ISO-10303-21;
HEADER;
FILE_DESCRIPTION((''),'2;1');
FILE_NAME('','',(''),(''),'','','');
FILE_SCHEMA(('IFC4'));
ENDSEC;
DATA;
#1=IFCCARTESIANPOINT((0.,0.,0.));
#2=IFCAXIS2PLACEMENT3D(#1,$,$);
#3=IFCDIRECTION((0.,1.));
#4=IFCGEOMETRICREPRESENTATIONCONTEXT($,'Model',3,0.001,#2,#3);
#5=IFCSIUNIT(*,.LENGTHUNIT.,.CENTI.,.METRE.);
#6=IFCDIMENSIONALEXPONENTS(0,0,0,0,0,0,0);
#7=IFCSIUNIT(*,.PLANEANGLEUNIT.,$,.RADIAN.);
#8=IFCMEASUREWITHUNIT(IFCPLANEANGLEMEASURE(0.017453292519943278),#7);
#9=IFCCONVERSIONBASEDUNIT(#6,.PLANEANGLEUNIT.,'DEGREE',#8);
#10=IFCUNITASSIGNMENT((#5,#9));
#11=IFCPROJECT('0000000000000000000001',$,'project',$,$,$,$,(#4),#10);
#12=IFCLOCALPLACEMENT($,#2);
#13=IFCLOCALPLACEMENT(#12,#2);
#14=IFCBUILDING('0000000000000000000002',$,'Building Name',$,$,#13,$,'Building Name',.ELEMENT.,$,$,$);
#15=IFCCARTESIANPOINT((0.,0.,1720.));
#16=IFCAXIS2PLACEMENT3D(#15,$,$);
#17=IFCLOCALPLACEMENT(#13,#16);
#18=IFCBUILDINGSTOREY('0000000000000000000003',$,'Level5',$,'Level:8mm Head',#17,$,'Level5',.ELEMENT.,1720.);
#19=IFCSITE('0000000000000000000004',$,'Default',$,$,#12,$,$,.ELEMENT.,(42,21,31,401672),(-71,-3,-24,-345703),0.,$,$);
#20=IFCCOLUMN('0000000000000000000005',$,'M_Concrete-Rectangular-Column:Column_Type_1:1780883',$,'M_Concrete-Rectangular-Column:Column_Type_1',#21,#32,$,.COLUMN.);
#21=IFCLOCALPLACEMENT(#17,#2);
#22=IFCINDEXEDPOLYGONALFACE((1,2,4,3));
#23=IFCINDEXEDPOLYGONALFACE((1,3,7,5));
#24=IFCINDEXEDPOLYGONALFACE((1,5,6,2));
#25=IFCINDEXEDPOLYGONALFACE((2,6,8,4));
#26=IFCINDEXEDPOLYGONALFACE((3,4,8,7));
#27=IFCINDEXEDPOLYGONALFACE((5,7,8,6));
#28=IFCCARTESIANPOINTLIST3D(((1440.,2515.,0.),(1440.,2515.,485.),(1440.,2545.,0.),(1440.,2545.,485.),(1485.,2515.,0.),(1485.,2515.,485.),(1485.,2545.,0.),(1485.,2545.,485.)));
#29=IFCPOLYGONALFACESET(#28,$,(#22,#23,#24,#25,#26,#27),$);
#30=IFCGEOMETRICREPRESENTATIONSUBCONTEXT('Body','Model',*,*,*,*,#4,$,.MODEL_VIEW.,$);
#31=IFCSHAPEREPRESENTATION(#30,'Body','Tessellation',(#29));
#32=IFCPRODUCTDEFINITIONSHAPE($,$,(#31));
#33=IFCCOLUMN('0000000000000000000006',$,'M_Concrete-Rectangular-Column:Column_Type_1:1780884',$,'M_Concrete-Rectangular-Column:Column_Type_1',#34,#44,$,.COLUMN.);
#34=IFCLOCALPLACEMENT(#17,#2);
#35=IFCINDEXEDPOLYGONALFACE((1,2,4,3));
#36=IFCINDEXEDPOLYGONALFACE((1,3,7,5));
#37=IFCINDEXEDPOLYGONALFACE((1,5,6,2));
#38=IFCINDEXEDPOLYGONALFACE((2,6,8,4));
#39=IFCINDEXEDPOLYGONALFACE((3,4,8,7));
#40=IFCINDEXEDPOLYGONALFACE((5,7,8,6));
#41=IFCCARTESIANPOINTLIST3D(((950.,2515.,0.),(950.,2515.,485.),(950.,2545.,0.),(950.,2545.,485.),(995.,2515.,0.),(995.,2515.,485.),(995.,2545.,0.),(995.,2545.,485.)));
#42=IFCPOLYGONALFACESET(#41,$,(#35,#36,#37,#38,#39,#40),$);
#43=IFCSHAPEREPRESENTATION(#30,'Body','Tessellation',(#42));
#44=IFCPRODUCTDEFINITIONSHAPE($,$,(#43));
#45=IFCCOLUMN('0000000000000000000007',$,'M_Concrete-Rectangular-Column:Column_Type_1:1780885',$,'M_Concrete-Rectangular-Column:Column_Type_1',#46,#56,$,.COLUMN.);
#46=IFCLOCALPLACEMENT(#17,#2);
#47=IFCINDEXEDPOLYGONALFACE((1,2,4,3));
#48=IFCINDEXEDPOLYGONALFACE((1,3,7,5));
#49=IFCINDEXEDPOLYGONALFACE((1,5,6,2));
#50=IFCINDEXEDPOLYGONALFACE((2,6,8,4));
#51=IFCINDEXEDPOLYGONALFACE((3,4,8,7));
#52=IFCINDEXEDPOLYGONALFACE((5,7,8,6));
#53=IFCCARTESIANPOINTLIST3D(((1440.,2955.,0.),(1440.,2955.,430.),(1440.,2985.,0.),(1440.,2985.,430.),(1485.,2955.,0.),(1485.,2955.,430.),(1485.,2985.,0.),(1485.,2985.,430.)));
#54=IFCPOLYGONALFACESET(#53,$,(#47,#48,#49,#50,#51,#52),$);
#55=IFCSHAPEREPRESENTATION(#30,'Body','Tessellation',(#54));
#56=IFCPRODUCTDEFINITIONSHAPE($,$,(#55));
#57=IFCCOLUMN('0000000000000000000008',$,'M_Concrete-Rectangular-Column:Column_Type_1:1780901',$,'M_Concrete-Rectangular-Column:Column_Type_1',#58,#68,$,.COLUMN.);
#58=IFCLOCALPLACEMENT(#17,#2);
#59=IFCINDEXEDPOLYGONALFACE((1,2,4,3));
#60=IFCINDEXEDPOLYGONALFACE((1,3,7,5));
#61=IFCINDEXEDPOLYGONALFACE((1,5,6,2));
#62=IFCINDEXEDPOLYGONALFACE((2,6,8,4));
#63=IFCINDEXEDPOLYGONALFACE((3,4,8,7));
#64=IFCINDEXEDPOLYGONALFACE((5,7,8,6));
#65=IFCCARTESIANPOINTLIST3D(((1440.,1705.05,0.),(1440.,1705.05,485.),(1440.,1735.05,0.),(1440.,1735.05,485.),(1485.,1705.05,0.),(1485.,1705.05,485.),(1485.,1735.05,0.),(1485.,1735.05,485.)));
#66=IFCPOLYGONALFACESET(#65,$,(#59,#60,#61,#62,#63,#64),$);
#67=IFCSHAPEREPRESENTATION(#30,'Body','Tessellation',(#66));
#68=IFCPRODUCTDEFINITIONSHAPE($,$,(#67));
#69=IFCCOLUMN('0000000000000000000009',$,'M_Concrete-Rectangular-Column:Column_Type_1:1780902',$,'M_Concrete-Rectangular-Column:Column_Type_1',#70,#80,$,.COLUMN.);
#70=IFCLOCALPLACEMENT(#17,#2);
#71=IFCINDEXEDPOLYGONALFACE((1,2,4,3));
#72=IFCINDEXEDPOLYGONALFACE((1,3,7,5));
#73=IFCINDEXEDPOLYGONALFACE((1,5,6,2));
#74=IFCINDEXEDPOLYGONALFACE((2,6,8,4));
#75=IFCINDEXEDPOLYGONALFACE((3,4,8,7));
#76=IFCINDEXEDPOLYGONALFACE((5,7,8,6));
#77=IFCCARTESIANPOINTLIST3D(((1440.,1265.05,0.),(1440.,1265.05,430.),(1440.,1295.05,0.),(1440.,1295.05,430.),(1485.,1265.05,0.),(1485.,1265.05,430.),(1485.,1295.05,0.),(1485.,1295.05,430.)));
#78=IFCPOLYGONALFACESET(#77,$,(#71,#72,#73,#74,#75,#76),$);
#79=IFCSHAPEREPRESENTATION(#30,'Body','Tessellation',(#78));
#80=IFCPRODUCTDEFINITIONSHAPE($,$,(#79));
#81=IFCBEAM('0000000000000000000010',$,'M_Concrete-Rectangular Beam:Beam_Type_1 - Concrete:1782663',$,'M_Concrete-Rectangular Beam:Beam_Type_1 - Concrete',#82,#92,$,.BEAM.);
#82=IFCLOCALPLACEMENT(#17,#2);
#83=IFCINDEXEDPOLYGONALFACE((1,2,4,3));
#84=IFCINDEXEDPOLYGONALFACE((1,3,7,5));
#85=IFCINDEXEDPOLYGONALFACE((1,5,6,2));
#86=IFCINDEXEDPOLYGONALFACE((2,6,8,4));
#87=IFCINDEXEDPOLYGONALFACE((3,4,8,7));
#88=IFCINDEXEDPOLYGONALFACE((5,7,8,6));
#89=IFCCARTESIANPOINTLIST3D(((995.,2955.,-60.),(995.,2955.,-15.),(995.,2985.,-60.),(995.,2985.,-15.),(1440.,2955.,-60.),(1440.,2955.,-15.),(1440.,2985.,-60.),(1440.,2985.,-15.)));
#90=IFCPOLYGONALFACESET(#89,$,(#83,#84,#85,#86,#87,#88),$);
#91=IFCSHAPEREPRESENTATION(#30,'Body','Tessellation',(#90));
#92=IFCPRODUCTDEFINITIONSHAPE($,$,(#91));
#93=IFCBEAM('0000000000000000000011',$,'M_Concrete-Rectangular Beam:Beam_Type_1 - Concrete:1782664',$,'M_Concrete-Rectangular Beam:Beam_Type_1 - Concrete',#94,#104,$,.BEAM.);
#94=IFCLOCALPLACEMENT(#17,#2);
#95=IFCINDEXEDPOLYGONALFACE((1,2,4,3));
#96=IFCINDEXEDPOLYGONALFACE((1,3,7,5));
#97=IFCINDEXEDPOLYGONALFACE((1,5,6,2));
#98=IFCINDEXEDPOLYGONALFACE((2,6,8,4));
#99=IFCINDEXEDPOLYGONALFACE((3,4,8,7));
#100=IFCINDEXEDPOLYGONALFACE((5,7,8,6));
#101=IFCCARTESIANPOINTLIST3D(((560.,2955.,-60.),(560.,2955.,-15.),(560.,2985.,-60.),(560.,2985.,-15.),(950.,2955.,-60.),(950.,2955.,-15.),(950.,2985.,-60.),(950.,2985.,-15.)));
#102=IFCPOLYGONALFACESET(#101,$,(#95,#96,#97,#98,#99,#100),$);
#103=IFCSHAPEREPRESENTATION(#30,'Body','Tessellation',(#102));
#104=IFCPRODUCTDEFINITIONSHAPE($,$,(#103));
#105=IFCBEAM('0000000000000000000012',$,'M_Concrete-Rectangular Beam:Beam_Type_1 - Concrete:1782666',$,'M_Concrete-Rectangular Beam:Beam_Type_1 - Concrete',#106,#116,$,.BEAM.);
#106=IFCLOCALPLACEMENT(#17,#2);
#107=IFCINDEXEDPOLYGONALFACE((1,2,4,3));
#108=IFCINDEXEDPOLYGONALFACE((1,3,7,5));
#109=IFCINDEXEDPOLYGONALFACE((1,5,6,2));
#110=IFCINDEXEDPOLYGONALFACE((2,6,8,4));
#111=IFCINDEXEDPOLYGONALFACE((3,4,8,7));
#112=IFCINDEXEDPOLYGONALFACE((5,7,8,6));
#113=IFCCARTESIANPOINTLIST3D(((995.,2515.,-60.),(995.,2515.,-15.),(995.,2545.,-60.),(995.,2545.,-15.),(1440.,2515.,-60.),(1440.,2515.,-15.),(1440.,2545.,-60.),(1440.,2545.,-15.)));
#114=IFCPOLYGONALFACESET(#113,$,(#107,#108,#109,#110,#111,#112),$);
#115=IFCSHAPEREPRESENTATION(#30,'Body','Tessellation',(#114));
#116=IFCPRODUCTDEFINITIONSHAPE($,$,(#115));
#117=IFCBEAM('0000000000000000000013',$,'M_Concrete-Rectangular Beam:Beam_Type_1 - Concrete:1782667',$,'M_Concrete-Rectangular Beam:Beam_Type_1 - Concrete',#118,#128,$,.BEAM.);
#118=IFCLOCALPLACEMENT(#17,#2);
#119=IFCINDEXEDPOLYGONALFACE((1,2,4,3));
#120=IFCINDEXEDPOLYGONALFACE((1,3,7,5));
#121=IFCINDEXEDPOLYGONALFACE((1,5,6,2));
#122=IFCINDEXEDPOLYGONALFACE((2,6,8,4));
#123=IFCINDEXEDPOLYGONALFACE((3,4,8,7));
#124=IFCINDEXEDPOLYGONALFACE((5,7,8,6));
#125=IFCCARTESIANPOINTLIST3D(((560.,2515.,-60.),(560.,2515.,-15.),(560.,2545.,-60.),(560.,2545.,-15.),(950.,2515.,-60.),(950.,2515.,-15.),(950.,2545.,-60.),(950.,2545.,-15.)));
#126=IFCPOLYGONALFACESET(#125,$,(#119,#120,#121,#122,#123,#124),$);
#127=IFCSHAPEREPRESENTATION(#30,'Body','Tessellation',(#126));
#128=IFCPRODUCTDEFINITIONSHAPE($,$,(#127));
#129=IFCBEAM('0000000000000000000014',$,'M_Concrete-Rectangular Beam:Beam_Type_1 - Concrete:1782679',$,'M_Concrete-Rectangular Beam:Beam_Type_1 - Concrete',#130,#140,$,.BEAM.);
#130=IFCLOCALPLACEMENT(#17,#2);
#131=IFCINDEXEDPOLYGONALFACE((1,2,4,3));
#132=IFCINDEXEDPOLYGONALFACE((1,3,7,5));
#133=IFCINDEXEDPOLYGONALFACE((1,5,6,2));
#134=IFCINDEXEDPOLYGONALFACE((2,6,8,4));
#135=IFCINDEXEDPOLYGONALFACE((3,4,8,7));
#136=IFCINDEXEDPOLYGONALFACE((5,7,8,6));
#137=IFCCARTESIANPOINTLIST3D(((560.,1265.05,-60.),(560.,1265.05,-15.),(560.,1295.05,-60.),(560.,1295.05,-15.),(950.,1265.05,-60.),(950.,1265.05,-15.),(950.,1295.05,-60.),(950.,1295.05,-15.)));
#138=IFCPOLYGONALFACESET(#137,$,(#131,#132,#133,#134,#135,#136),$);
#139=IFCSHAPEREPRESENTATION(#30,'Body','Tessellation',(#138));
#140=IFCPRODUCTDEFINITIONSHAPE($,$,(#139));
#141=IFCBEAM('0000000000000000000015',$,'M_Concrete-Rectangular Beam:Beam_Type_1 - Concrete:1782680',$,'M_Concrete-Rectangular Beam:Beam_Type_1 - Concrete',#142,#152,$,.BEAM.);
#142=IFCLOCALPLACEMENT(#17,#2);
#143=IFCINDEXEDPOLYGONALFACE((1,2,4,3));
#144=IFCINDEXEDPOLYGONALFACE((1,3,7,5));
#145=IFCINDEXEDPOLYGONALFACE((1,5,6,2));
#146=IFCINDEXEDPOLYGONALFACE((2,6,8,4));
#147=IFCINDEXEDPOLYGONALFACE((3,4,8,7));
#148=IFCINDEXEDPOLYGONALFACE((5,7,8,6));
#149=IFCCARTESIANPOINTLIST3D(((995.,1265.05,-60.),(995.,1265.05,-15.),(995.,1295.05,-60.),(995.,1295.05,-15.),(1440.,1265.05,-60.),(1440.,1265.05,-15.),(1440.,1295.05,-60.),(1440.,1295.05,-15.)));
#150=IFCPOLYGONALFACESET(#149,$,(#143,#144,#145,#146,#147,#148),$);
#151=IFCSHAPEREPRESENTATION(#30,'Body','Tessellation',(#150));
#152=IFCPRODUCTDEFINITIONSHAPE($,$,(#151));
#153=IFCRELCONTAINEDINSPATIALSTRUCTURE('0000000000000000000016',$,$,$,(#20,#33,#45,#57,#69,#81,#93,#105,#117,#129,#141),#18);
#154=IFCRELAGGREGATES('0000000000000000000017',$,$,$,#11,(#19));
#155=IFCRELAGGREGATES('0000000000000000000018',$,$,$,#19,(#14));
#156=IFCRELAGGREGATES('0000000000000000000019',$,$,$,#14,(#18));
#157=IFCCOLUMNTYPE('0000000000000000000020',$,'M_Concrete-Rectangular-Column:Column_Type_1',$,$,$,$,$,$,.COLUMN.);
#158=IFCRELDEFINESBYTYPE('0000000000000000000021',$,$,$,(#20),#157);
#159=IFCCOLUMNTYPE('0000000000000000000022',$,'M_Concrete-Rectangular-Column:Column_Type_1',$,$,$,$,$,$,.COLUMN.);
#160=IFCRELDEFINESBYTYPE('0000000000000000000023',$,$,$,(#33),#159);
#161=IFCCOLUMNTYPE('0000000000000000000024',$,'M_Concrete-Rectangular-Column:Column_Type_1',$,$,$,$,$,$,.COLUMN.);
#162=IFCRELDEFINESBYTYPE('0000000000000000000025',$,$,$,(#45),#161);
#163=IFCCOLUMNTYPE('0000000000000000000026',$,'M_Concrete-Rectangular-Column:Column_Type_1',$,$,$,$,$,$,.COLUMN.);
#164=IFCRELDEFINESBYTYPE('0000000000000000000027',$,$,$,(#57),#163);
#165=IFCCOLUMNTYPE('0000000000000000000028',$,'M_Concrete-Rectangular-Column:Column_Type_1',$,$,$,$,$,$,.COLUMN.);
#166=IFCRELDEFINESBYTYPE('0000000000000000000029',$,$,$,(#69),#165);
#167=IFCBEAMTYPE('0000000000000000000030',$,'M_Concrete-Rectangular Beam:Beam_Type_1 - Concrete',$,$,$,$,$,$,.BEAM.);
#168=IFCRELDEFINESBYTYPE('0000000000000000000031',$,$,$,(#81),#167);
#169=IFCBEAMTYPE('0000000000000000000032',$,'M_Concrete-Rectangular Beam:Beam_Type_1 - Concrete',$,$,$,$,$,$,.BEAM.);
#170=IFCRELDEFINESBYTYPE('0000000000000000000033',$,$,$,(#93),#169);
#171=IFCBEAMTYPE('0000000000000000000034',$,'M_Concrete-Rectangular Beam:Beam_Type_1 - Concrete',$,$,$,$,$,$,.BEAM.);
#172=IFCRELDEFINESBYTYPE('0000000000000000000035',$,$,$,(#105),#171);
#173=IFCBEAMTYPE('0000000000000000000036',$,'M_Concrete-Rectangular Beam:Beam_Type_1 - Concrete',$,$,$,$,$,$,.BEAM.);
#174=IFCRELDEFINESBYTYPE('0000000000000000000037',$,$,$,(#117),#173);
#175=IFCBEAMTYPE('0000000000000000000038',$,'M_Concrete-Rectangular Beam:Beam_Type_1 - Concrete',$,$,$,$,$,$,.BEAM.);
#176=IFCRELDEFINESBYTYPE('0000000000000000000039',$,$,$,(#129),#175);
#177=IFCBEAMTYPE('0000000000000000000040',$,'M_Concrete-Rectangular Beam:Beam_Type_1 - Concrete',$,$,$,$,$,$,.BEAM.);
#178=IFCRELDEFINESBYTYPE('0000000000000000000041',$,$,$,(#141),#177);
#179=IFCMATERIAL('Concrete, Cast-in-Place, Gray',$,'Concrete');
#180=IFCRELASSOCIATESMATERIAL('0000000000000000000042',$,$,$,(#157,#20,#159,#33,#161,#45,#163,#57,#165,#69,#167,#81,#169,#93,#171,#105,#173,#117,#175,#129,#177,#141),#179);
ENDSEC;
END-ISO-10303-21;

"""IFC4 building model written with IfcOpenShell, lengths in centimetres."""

from ifc_helpers import new_model, entity, si_unit, converted_unit, direction, frame, origin, place, context, subcontext, project, spatial, indexed_curve, outline, extrude, source, transform, mapped, material, type_object, type_shapes, element, save


model = new_model("IFC4")

# Units and contexts
model_context = context("Model", 3, precision=0.001, world=origin(), true_north=direction((0.0, 1.0)))
body_context = subcontext(model_context, "Body", "Model", "MODEL_VIEW")
ifc_project = project(units=[si_unit("LENGTHUNIT", "METRE", prefix="CENTI"), converted_unit("PLANEANGLEUNIT", "DEGREE", entity("IfcPlaneAngleMeasure", 0.017453292519943278), si_unit("PLANEANGLEUNIT", "RADIAN"), dimensions=[0, 0, 0, 0, 0, 0, 0])], contexts=[model_context])

# Site, building, storey
site_placement = place(None, origin())
site = spatial("IfcSite", under=ifc_project, at=site_placement, Name="Default", CompositionType="ELEMENT", RefLatitude=(42, 21, 31, 401672), RefLongitude=(-71, -3, -24, -345703), RefElevation=0.0)
building_placement = place(site_placement, origin())
building = spatial("IfcBuilding", under=site, at=building_placement, Name="Building Name", LongName="Building Name", CompositionType="ELEMENT")
storey_placement = place(building_placement, frame((0.0, 0.0, 1720.0)))
storey = spatial("IfcBuildingStorey", under=building, at=storey_placement, Name="Level5", ObjectType="Level:8mm Head", LongName="Level5", CompositionType="ELEMENT", Elevation=1720.0)

# Columns
ifc_material = material(Name="Concrete, Cast-in-Place, Gray", Category="Concrete")
column_type_1 = type_object("IfcColumnType", Name="M_Concrete-Rectangular-Column:Column_Type_1", PredefinedType="COLUMN", material=ifc_material)
shared_shape_1 = source(origin(), body_context, "Body", "SweptSolid", [
    extrude(outline(indexed_curve([(-15.0, -22.5), (15.0, -22.5), (15.0, 22.5), (-15.0, 22.5), (-15.0, -22.5)], self_intersect=False)), frame((1462.5, 2530.0, 1720.0), z_axis=(0.0, 0.0, 1.0), x_axis=(0.0, -1.0, 0.0)), (0.0, 0.0, 1.0), 485.0),
])
type_shapes(column_type_1, [shared_shape_1])
column_1_placement = place(storey_placement, frame((0.0, 0.0, -1720.0)))
element("IfcColumn", 1, at=column_1_placement, inside=storey, type_object=column_type_1, material=ifc_material, Name="M_Concrete-Rectangular-Column:Column_Type_1:1780883", ObjectType="M_Concrete-Rectangular-Column:Column_Type_1", PredefinedType="COLUMN", context=body_context, shape_type="MappedRepresentation", body=[
    mapped(shared_shape_1, transform((0.0, 0.0, 0.0), scale=1.0)),
])
column_type_2 = type_object("IfcColumnType", Name="M_Concrete-Rectangular-Column:Column_Type_1", PredefinedType="COLUMN", material=ifc_material)
shared_shape_2 = source(origin(), body_context, "Body", "SweptSolid", [
    extrude(outline(indexed_curve([(-15.0, -22.5), (15.0, -22.5), (15.0, 22.5), (-15.0, 22.5), (-15.0, -22.5)], self_intersect=False)), frame((972.5, 2530.0, 1720.0), z_axis=(0.0, 0.0, 1.0), x_axis=(0.0, -1.0, 0.0)), (0.0, 0.0, 1.0), 485.0),
])
type_shapes(column_type_2, [shared_shape_2])
column_2_placement = place(storey_placement, frame((0.0, 0.0, -1720.0)))
element("IfcColumn", 2, at=column_2_placement, inside=storey, type_object=column_type_2, material=ifc_material, Name="M_Concrete-Rectangular-Column:Column_Type_1:1780884", ObjectType="M_Concrete-Rectangular-Column:Column_Type_1", PredefinedType="COLUMN", context=body_context, shape_type="MappedRepresentation", body=[
    mapped(shared_shape_2, transform((0.0, 0.0, 0.0), scale=1.0)),
])
column_type_3 = type_object("IfcColumnType", Name="M_Concrete-Rectangular-Column:Column_Type_1", PredefinedType="COLUMN", material=ifc_material)
shared_shape_3 = source(origin(), body_context, "Body", "SweptSolid", [
    extrude(outline(indexed_curve([(-22.5, -15.0), (22.5, -15.0), (22.5, 15.0), (-22.5, 15.0), (-22.5, -15.0)], self_intersect=False)), frame((1462.5, 2970.0, 1720.0)), (0.0, 0.0, 1.0), 430.0),
])
type_shapes(column_type_3, [shared_shape_3])
column_3_placement = place(storey_placement, frame((0.0, 0.0, -1720.0)))
element("IfcColumn", 3, at=column_3_placement, inside=storey, type_object=column_type_3, material=ifc_material, Name="M_Concrete-Rectangular-Column:Column_Type_1:1780885", ObjectType="M_Concrete-Rectangular-Column:Column_Type_1", PredefinedType="COLUMN", context=body_context, shape_type="MappedRepresentation", body=[
    mapped(shared_shape_3, transform((0.0, 0.0, 0.0), scale=1.0)),
])
column_type_4 = type_object("IfcColumnType", Name="M_Concrete-Rectangular-Column:Column_Type_1", PredefinedType="COLUMN", material=ifc_material)
shared_shape_4 = source(origin(), body_context, "Body", "SweptSolid", [
    extrude(outline(indexed_curve([(-22.5, -15.0), (22.5, -15.0), (22.5, 15.0), (-22.5, 15.0), (-22.5, -15.0)], self_intersect=False)), frame((1462.5, 1720.05, 1720.0)), (0.0, 0.0, 1.0), 485.0),
])
type_shapes(column_type_4, [shared_shape_4])
column_4_placement = place(storey_placement, frame((0.0, 0.0, -1720.0)))
element("IfcColumn", 4, at=column_4_placement, inside=storey, type_object=column_type_4, material=ifc_material, Name="M_Concrete-Rectangular-Column:Column_Type_1:1780901", ObjectType="M_Concrete-Rectangular-Column:Column_Type_1", PredefinedType="COLUMN", context=body_context, shape_type="MappedRepresentation", body=[
    mapped(shared_shape_4, transform((0.0, 0.0, 0.0), scale=1.0)),
])
column_type_5 = type_object("IfcColumnType", Name="M_Concrete-Rectangular-Column:Column_Type_1", PredefinedType="COLUMN", material=ifc_material)
shared_shape_5 = source(origin(), body_context, "Body", "SweptSolid", [
    extrude(outline(indexed_curve([(-15.0, -22.5), (15.0, -22.5), (15.0, 22.5), (-15.0, 22.5), (-15.0, -22.5)], self_intersect=False)), frame((1462.5, 1280.05, 1720.0), z_axis=(0.0, 0.0, 1.0), x_axis=(0.0, -1.0, 0.0)), (0.0, 0.0, 1.0), 430.0),
])
type_shapes(column_type_5, [shared_shape_5])
column_5_placement = place(storey_placement, frame((0.0, 0.0, -1720.0)))
element("IfcColumn", 5, at=column_5_placement, inside=storey, type_object=column_type_5, material=ifc_material, Name="M_Concrete-Rectangular-Column:Column_Type_1:1780902", ObjectType="M_Concrete-Rectangular-Column:Column_Type_1", PredefinedType="COLUMN", context=body_context, shape_type="MappedRepresentation", body=[
    mapped(shared_shape_5, transform((0.0, 0.0, 0.0), scale=1.0)),
])

# Beams
beam_type_1 = type_object("IfcBeamType", Name="M_Concrete-Rectangular Beam:Beam_Type_1 - Concrete", PredefinedType="BEAM", material=ifc_material)
shared_shape_6 = source(origin(), body_context, "Body", "SweptSolid", [
    extrude(outline(indexed_curve([(-22.5, -15.0), (22.5, -15.0), (22.5, 15.0), (-22.5, 15.0), (-22.5, -15.0)], self_intersect=False)), frame((995.0, 2970.0, 1682.5), z_axis=(1.0, 0.0, 0.0), x_axis=(0.0, 0.0, -1.0)), (0.0, 0.0, 1.0), 445.0),
])
type_shapes(beam_type_1, [shared_shape_6])
beam_1_placement = place(storey_placement, frame((0.0, 0.0, -1720.0)))
element("IfcBeam", 6, at=beam_1_placement, inside=storey, type_object=beam_type_1, material=ifc_material, Name="M_Concrete-Rectangular Beam:Beam_Type_1 - Concrete:1782663", ObjectType="M_Concrete-Rectangular Beam:Beam_Type_1 - Concrete", PredefinedType="BEAM", context=body_context, shape_type="MappedRepresentation", body=[
    mapped(shared_shape_6, transform((0.0, 0.0, 0.0), scale=1.0)),
])
beam_type_2 = type_object("IfcBeamType", Name="M_Concrete-Rectangular Beam:Beam_Type_1 - Concrete", PredefinedType="BEAM", material=ifc_material)
shared_shape_7 = source(origin(), body_context, "Body", "SweptSolid", [
    extrude(outline(indexed_curve([(-22.5, -15.0), (22.5, -15.0), (22.5, 15.0), (-22.5, 15.0), (-22.5, -15.0)], self_intersect=False)), frame((560.0, 2970.0, 1682.5), z_axis=(1.0, 0.0, 0.0), x_axis=(0.0, 0.0, -1.0)), (0.0, 0.0, 1.0), 390.0),
])
type_shapes(beam_type_2, [shared_shape_7])
beam_2_placement = place(storey_placement, frame((0.0, 0.0, -1720.0)))
element("IfcBeam", 7, at=beam_2_placement, inside=storey, type_object=beam_type_2, material=ifc_material, Name="M_Concrete-Rectangular Beam:Beam_Type_1 - Concrete:1782664", ObjectType="M_Concrete-Rectangular Beam:Beam_Type_1 - Concrete", PredefinedType="BEAM", context=body_context, shape_type="MappedRepresentation", body=[
    mapped(shared_shape_7, transform((0.0, 0.0, 0.0), scale=1.0)),
])
beam_type_3 = type_object("IfcBeamType", Name="M_Concrete-Rectangular Beam:Beam_Type_1 - Concrete", PredefinedType="BEAM", material=ifc_material)
shared_shape_8 = source(origin(), body_context, "Body", "SweptSolid", [
    extrude(outline(indexed_curve([(-22.5, -15.0), (22.5, -15.0), (22.5, 15.0), (-22.5, 15.0), (-22.5, -15.0)], self_intersect=False)), frame((995.0, 2530.0, 1682.5), z_axis=(1.0, 0.0, 0.0), x_axis=(0.0, 0.0, -1.0)), (0.0, 0.0, 1.0), 445.0),
])
type_shapes(beam_type_3, [shared_shape_8])
beam_3_placement = place(storey_placement, frame((0.0, 0.0, -1720.0)))
element("IfcBeam", 8, at=beam_3_placement, inside=storey, type_object=beam_type_3, material=ifc_material, Name="M_Concrete-Rectangular Beam:Beam_Type_1 - Concrete:1782666", ObjectType="M_Concrete-Rectangular Beam:Beam_Type_1 - Concrete", PredefinedType="BEAM", context=body_context, shape_type="MappedRepresentation", body=[
    mapped(shared_shape_8, transform((0.0, 0.0, 0.0), scale=1.0)),
])
beam_type_4 = type_object("IfcBeamType", Name="M_Concrete-Rectangular Beam:Beam_Type_1 - Concrete", PredefinedType="BEAM", material=ifc_material)
shared_shape_9 = source(origin(), body_context, "Body", "SweptSolid", [
    extrude(outline(indexed_curve([(-22.5, -15.0), (22.5, -15.0), (22.5, 15.0), (-22.5, 15.0), (-22.5, -15.0)], self_intersect=False)), frame((560.0, 2530.0, 1682.5), z_axis=(1.0, 0.0, 0.0), x_axis=(0.0, 0.0, -1.0)), (0.0, 0.0, 1.0), 390.0),
])
type_shapes(beam_type_4, [shared_shape_9])
beam_4_placement = place(storey_placement, frame((0.0, 0.0, -1720.0)))
element("IfcBeam", 9, at=beam_4_placement, inside=storey, type_object=beam_type_4, material=ifc_material, Name="M_Concrete-Rectangular Beam:Beam_Type_1 - Concrete:1782667", ObjectType="M_Concrete-Rectangular Beam:Beam_Type_1 - Concrete", PredefinedType="BEAM", context=body_context, shape_type="MappedRepresentation", body=[
    mapped(shared_shape_9, transform((0.0, 0.0, 0.0), scale=1.0)),
])
beam_type_5 = type_object("IfcBeamType", Name="M_Concrete-Rectangular Beam:Beam_Type_1 - Concrete", PredefinedType="BEAM", material=ifc_material)
shared_shape_10 = source(origin(), body_context, "Body", "SweptSolid", [
    extrude(outline(indexed_curve([(-22.5, -15.0), (22.5, -15.0), (22.5, 15.0), (-22.5, 15.0), (-22.5, -15.0)], self_intersect=False)), frame((560.0, 1280.05, 1682.5), z_axis=(1.0, 0.0, 0.0), x_axis=(0.0, 0.0, -1.0)), (0.0, 0.0, 1.0), 390.0),
])
type_shapes(beam_type_5, [shared_shape_10])
beam_5_placement = place(storey_placement, frame((0.0, 0.0, -1720.0)))
element("IfcBeam", 10, at=beam_5_placement, inside=storey, type_object=beam_type_5, material=ifc_material, Name="M_Concrete-Rectangular Beam:Beam_Type_1 - Concrete:1782679", ObjectType="M_Concrete-Rectangular Beam:Beam_Type_1 - Concrete", PredefinedType="BEAM", context=body_context, shape_type="MappedRepresentation", body=[
    mapped(shared_shape_10, transform((0.0, 0.0, 0.0), scale=1.0)),
])
beam_type_6 = type_object("IfcBeamType", Name="M_Concrete-Rectangular Beam:Beam_Type_1 - Concrete", PredefinedType="BEAM", material=ifc_material)
shared_shape_11 = source(origin(), body_context, "Body", "SweptSolid", [
    extrude(outline(indexed_curve([(-22.5, -15.0), (22.5, -15.0), (22.5, 15.0), (-22.5, 15.0), (-22.5, -15.0)], self_intersect=False)), frame((995.0, 1280.05, 1682.5), z_axis=(1.0, 0.0, 0.0), x_axis=(0.0, 0.0, -1.0)), (0.0, 0.0, 1.0), 445.0),
])
type_shapes(beam_type_6, [shared_shape_11])
beam_6_placement = place(storey_placement, frame((0.0, 0.0, -1720.0)))
element("IfcBeam", 11, at=beam_6_placement, inside=storey, type_object=beam_type_6, material=ifc_material, Name="M_Concrete-Rectangular Beam:Beam_Type_1 - Concrete:1782680", ObjectType="M_Concrete-Rectangular Beam:Beam_Type_1 - Concrete", PredefinedType="BEAM", context=body_context, shape_type="MappedRepresentation", body=[
    mapped(shared_shape_11, transform((0.0, 0.0, 0.0), scale=1.0)),
])

save(model, "model.ifc")
